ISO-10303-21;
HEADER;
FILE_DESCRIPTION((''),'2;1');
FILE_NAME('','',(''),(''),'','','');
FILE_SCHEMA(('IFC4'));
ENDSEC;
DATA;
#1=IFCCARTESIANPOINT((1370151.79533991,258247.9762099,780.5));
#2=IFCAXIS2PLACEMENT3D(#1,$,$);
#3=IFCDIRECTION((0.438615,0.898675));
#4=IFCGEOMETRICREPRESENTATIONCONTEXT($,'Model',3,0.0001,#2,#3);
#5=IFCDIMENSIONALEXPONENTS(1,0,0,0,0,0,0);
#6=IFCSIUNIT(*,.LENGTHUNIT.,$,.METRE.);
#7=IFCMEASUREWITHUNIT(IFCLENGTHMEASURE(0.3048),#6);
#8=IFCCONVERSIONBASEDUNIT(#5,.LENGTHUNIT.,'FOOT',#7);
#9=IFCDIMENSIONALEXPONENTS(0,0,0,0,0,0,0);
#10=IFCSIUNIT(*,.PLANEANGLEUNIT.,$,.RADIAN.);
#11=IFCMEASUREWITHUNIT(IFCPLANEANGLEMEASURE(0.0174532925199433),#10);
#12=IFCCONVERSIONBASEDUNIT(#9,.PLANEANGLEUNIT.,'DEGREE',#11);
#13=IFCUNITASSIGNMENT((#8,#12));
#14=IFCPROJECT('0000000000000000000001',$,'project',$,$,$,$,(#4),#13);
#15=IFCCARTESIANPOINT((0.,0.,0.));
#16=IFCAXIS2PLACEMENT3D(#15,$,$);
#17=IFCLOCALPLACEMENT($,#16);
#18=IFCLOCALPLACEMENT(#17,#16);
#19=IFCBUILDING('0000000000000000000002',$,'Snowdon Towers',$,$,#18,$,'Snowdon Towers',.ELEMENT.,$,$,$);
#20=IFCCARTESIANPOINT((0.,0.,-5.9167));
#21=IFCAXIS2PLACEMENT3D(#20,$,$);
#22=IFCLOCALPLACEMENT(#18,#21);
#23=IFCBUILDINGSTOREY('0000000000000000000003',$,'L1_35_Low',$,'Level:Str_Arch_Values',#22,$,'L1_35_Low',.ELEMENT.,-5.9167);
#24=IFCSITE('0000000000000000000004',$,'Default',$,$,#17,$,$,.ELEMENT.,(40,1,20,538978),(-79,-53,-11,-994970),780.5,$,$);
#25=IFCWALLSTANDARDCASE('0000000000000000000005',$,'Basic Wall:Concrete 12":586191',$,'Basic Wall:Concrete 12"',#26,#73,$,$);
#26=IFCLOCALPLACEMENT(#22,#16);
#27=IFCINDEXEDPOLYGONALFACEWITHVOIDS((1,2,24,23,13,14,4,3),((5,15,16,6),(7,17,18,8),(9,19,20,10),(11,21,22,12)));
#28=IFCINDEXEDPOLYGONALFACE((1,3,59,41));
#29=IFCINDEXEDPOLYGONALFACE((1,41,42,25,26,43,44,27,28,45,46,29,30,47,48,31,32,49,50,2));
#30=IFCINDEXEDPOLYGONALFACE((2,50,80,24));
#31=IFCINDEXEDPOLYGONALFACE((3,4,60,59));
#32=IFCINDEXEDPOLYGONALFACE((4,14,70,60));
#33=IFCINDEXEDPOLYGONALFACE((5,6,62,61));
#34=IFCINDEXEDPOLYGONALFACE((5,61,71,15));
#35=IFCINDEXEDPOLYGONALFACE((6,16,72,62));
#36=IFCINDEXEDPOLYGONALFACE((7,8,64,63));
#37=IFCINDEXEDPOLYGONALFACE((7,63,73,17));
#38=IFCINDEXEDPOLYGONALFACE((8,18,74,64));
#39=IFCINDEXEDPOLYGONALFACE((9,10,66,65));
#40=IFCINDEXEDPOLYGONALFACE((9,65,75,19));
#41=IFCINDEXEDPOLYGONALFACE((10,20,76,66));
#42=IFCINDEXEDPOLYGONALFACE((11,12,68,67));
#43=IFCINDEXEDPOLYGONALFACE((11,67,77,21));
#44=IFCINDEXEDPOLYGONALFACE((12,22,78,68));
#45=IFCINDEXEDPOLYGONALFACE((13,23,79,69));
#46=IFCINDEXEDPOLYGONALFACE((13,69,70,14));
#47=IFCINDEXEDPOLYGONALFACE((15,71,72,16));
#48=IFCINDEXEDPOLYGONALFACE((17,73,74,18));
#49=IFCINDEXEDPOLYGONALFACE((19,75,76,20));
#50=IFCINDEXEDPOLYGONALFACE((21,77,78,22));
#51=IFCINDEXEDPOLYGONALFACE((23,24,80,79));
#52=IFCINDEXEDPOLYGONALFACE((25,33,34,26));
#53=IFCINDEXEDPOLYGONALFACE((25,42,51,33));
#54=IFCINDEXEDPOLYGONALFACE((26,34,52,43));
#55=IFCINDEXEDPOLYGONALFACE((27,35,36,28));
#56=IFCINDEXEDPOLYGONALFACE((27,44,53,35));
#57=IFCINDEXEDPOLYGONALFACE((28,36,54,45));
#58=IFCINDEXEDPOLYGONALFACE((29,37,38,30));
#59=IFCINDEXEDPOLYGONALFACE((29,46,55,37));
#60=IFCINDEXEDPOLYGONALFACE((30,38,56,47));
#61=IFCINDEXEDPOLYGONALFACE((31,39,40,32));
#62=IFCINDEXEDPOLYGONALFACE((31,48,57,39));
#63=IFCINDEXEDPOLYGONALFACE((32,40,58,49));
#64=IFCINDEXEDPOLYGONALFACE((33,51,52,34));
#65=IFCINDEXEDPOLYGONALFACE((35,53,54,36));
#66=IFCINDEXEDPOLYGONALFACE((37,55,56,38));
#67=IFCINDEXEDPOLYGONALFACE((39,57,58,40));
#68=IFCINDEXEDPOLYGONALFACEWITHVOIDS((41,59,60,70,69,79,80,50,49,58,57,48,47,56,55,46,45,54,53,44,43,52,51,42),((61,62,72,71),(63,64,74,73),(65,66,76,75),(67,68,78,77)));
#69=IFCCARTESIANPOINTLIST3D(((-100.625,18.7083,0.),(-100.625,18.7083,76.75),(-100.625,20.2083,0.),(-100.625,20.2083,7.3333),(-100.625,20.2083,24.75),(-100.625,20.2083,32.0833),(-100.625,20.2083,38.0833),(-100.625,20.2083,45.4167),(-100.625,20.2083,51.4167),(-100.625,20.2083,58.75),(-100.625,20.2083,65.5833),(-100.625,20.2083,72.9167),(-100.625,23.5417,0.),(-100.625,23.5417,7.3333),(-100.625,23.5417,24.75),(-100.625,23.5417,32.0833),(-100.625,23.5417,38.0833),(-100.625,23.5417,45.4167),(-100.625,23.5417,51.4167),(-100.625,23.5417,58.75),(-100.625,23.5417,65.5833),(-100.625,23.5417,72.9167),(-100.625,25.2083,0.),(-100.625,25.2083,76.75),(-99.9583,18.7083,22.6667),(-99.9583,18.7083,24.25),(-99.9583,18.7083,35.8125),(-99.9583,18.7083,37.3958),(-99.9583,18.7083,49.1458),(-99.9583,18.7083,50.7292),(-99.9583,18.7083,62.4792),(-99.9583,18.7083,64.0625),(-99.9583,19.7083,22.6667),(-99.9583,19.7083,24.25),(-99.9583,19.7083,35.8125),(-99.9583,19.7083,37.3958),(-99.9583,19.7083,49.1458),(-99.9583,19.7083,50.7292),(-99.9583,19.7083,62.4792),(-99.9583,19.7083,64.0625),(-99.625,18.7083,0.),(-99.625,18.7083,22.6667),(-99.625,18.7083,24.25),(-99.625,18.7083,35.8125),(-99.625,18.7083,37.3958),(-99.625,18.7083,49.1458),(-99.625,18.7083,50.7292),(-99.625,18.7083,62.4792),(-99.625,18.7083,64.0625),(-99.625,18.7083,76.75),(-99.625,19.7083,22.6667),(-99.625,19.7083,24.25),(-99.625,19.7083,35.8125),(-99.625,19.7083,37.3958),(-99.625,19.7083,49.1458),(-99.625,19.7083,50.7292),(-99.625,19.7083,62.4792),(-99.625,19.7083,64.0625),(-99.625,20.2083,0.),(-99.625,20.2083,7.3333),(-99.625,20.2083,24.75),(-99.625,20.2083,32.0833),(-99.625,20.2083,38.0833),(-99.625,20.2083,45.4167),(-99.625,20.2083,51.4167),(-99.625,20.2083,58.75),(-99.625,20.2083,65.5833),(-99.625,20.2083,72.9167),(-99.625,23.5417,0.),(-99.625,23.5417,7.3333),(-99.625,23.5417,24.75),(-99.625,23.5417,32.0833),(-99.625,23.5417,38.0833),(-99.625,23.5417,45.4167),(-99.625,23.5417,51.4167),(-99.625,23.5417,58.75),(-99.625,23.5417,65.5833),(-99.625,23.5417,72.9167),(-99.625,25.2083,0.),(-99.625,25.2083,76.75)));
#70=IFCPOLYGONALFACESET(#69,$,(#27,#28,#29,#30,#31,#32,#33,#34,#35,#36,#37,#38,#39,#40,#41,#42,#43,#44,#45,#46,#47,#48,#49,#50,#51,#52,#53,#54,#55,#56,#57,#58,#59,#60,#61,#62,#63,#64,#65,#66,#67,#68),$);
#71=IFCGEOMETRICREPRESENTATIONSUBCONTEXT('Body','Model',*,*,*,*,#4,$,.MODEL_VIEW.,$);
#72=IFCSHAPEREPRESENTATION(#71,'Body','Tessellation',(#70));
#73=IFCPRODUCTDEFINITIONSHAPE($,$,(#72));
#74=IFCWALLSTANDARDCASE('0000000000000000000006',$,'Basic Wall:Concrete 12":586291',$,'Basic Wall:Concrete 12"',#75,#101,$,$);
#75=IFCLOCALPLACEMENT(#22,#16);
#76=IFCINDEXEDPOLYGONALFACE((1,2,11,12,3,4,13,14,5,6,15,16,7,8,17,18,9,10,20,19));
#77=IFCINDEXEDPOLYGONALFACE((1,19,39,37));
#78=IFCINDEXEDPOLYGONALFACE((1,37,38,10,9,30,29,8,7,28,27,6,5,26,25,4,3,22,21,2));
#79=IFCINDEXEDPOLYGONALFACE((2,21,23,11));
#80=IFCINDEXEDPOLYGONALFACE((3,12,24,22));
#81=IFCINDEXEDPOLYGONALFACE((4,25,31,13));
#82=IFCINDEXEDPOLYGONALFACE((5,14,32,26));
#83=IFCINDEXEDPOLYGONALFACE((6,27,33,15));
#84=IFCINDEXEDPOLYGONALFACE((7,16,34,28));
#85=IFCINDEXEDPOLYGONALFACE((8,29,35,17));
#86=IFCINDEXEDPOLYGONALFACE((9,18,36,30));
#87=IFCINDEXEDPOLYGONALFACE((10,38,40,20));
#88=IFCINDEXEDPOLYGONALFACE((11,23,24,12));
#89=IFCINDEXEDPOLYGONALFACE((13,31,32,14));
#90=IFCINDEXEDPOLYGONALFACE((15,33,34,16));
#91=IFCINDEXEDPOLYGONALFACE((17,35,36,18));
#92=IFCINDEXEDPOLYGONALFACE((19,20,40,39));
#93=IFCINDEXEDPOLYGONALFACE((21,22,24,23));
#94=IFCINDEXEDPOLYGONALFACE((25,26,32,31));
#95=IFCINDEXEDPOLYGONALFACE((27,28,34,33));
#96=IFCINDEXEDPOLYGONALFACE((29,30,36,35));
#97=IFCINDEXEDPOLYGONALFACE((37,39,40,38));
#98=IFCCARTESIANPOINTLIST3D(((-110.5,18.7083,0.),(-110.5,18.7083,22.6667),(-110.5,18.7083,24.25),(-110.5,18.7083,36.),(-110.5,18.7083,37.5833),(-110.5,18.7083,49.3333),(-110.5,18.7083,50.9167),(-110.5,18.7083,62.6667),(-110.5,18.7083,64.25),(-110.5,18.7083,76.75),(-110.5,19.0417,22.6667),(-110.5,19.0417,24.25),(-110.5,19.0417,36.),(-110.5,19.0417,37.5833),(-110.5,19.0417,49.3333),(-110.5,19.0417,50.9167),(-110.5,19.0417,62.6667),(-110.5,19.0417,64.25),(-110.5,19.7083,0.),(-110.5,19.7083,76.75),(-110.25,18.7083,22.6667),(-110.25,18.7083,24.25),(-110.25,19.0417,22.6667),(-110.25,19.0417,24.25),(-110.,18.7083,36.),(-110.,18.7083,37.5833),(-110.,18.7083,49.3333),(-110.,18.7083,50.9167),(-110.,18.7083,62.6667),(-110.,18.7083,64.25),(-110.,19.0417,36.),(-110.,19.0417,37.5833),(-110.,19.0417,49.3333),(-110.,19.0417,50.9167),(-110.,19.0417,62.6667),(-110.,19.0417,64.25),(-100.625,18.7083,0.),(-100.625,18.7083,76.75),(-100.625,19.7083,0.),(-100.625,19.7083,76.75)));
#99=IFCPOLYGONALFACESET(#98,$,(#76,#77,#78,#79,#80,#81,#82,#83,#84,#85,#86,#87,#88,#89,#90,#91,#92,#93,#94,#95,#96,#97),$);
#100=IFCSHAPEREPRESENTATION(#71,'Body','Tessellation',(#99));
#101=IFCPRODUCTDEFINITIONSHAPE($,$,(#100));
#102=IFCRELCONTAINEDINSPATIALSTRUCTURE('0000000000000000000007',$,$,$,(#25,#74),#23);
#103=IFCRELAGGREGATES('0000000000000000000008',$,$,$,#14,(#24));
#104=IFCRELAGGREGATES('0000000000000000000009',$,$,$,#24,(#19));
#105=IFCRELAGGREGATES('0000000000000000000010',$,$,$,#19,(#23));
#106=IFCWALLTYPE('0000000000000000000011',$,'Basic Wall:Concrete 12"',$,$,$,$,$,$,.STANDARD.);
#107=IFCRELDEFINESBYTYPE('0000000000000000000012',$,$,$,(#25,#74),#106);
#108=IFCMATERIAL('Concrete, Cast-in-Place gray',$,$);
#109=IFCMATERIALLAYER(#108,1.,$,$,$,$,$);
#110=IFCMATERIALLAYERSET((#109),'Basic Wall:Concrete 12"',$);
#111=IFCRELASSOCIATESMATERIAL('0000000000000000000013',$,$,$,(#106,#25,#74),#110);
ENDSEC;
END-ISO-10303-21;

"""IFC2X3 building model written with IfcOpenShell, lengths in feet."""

from ifc_helpers import new_model, entity, si_unit, converted_unit, direction, frame, frame_2d, origin, place, context, subcontext, project, spatial, rectangle, extrude, material, layer, layer_set, layer_usage, type_object, element, save


model = new_model("IFC2X3")

# Units and contexts
model_context = context("Model", 3, precision=0.0001, world=frame((1370151.79533991, 258247.9762099, 780.5)), true_north=direction((0.438615, 0.898675)))
body_context = subcontext(model_context, "Body", "Model", "MODEL_VIEW")
ifc_project = project(units=[converted_unit("LENGTHUNIT", "FOOT", entity("IfcLengthMeasure", 0.3048), si_unit("LENGTHUNIT", "METRE"), dimensions=[1, 0, 0, 0, 0, 0, 0]), converted_unit("PLANEANGLEUNIT", "DEGREE", entity("IfcPlaneAngleMeasure", 0.0174532925199433), si_unit("PLANEANGLEUNIT", "RADIAN"), dimensions=[0, 0, 0, 0, 0, 0, 0])], contexts=[model_context])

# Site, building, storey
site_placement = place(None, origin())
site = spatial("IfcSite", under=ifc_project, at=site_placement, Name="Default", CompositionType="ELEMENT", RefLatitude=(40, 1, 20, 538978), RefLongitude=(-79, -53, -11, -994970), RefElevation=780.5)
building_placement = place(site_placement, origin())
building = spatial("IfcBuilding", under=site, at=building_placement, Name="Snowdon Towers", LongName="Snowdon Towers", CompositionType="ELEMENT")
storey_placement = place(building_placement, frame((0.0, 0.0, -5.9167)))
storey = spatial("IfcBuildingStorey", under=building, at=storey_placement, Name="L1_35_Low", ObjectType="Level:Str_Arch_Values", LongName="L1_35_Low", CompositionType="ELEMENT", Elevation=-5.9167)

# Shared definitions
ifc_material = material(Name="Concrete, Cast-in-Place gray")

# Walls, openings
ifc_layer = layer(ifc_material, 1.0)
ifc_layer_set = layer_set([ifc_layer], Name="Basic Wall:Concrete 12\"")
ifc_layer_usage_1 = layer_usage(ifc_layer_set, "AXIS2", "POSITIVE", -0.5)
wall_type = type_object("IfcWallType", Name="Basic Wall:Concrete 12\"", PredefinedType="STANDARD", material=ifc_layer_set)
wall_1_placement = place(storey_placement, frame((-100.125, 25.2083, 0.0), z_axis=(0.0, 0.0, 1.0), x_axis=(0.0, -1.0, 0.0)))
wall_1 = element("IfcWallStandardCase", 1, at=wall_1_placement, inside=storey, type_object=wall_type, material=ifc_layer_usage_1, Name="Basic Wall:Concrete 12\":586191", ObjectType="Basic Wall:Concrete 12\"", context=body_context, shape_type="SweptSolid", body=[
    extrude(rectangle(XDim=6.5, YDim=1.0, at=frame_2d((3.25, 0.0), x_axis=(1.0, 0.0))), origin(), (0.0, 0.0, 1.0), 76.75),
])
opening_1_placement = place(wall_1_placement, origin())
element("IfcOpeningElement", 2, at=opening_1_placement, cuts=wall_1, ObjectType="Opening", context=body_context, shape_type="SweptSolid", body=[
    extrude(rectangle(XDim=7.3333, YDim=3.3333, at=frame_2d((0.0, 0.0), x_axis=(1.0, 0.0))), frame((3.3333, -4.5, 3.6667), z_axis=(0.0, 1.0, 0.0), x_axis=(0.0, 0.0, 1.0)), (0.0, 0.0, 1.0), 10.0),
])
opening_2_placement = place(wall_1_placement, origin())
element("IfcOpeningElement", 3, at=opening_2_placement, cuts=wall_1, ObjectType="Recess", context=body_context, shape_type="SweptSolid", body=[
    extrude(rectangle(XDim=1.5833, YDim=1.0, at=frame_2d((0.0, 0.0), x_axis=(0.0, 1.0))), frame((6.0, 0.1667, 23.4583), z_axis=(0.0, 1.0, 0.0), x_axis=(1.0, 0.0, 0.0)), (0.0, 0.0, 1.0), 0.3333),
])
opening_3_placement = place(wall_1_placement, origin())
element("IfcOpeningElement", 4, at=opening_3_placement, cuts=wall_1, ObjectType="Recess", context=body_context, shape_type="SweptSolid", body=[
    extrude(rectangle(XDim=1.5833, YDim=1.0, at=frame_2d((0.0, 0.0), x_axis=(0.0, 1.0))), frame((6.0, 0.1667, 63.2708), z_axis=(0.0, 1.0, 0.0), x_axis=(1.0, 0.0, 0.0)), (0.0, 0.0, 1.0), 0.3333),
])
opening_4_placement = place(wall_1_placement, origin())
element("IfcOpeningElement", 5, at=opening_4_placement, cuts=wall_1, ObjectType="Recess", context=body_context, shape_type="SweptSolid", body=[
    extrude(rectangle(XDim=1.5833, YDim=1.0, at=frame_2d((0.0, 0.0), x_axis=(0.0, 1.0))), frame((6.0, 0.1667, 36.6042), z_axis=(0.0, 1.0, 0.0), x_axis=(1.0, 0.0, 0.0)), (0.0, 0.0, 1.0), 0.3333),
])
opening_5_placement = place(wall_1_placement, origin())
element("IfcOpeningElement", 6, at=opening_5_placement, cuts=wall_1, ObjectType="Recess", context=body_context, shape_type="SweptSolid", body=[
    extrude(rectangle(XDim=1.5833, YDim=1.0, at=frame_2d((0.0, 0.0), x_axis=(0.0, 1.0))), frame((6.0, 0.1667, 49.9375), z_axis=(0.0, 1.0, 0.0), x_axis=(1.0, 0.0, 0.0)), (0.0, 0.0, 1.0), 0.3333),
])
opening_6_placement = place(wall_1_placement, origin())
element("IfcOpeningElement", 7, at=opening_6_placement, cuts=wall_1, ObjectType="Opening", context=body_context, shape_type="SweptSolid", body=[
    extrude(rectangle(XDim=7.3333, YDim=3.3333, at=frame_2d((0.0, 0.0), x_axis=(1.0, 0.0))), frame((3.3333, -4.5, 28.4167), z_axis=(0.0, 1.0, 0.0), x_axis=(0.0, 0.0, 1.0)), (0.0, 0.0, 1.0), 10.0),
])
opening_7_placement = place(wall_1_placement, origin())
element("IfcOpeningElement", 8, at=opening_7_placement, cuts=wall_1, ObjectType="Opening", context=body_context, shape_type="SweptSolid", body=[
    extrude(rectangle(XDim=7.3333, YDim=3.3333, at=frame_2d((0.0, 0.0), x_axis=(1.0, 0.0))), frame((3.3333, -4.5, 41.75), z_axis=(0.0, 1.0, 0.0), x_axis=(0.0, 0.0, 1.0)), (0.0, 0.0, 1.0), 10.0),
])
opening_8_placement = place(wall_1_placement, origin())
element("IfcOpeningElement", 9, at=opening_8_placement, cuts=wall_1, ObjectType="Opening", context=body_context, shape_type="SweptSolid", body=[
    extrude(rectangle(XDim=7.3333, YDim=3.3333, at=frame_2d((0.0, 0.0), x_axis=(1.0, 0.0))), frame((3.3333, -4.5, 55.0833), z_axis=(0.0, 1.0, 0.0), x_axis=(0.0, 0.0, 1.0)), (0.0, 0.0, 1.0), 10.0),
])
opening_9_placement = place(wall_1_placement, origin())
element("IfcOpeningElement", 10, at=opening_9_placement, cuts=wall_1, ObjectType="Opening", context=body_context, shape_type="SweptSolid", body=[
    extrude(rectangle(XDim=7.3333, YDim=3.3333, at=frame_2d((0.0, 0.0), x_axis=(1.0, 0.0))), frame((3.3333, -4.5, 69.25), z_axis=(0.0, 1.0, 0.0), x_axis=(0.0, 0.0, 1.0)), (0.0, 0.0, 1.0), 10.0),
])
ifc_layer_usage_2 = layer_usage(ifc_layer_set, "AXIS2", "POSITIVE", -0.5)
wall_2_placement = place(storey_placement, frame((-100.625, 19.2083, 0.0), z_axis=(0.0, 0.0, 1.0), x_axis=(-1.0, 0.0, 0.0)))
wall_2 = element("IfcWallStandardCase", 11, at=wall_2_placement, inside=storey, type_object=wall_type, material=ifc_layer_usage_2, Name="Basic Wall:Concrete 12\":586291", ObjectType="Basic Wall:Concrete 12\"", context=body_context, shape_type="SweptSolid", body=[
    extrude(rectangle(XDim=9.875, YDim=1.0, at=frame_2d((4.9375, 0.0), x_axis=(-1.0, 0.0))), origin(), (0.0, 0.0, 1.0), 76.75),
])
opening_10_placement = place(wall_2_placement, origin())
element("IfcOpeningElement", 12, at=opening_10_placement, cuts=wall_2, ObjectType="Recess", context=body_context, shape_type="SweptSolid", body=[
    extrude(rectangle(XDim=1.5833, YDim=1.0, at=frame_2d((0.0, 0.0), x_axis=(0.0, 1.0))), frame((10.125, 0.1667, 23.4583), z_axis=(0.0, 1.0, 0.0), x_axis=(1.0, 0.0, 0.0)), (0.0, 0.0, 1.0), 0.3333),
])
opening_11_placement = place(wall_2_placement, origin())
element("IfcOpeningElement", 13, at=opening_11_placement, cuts=wall_2, ObjectType="Recess", context=body_context, shape_type="SweptSolid", body=[
    extrude(rectangle(XDim=1.5833, YDim=1.0, at=frame_2d((0.0, 0.0), x_axis=(0.0, 1.0))), frame((9.875, 0.1667, 63.4583), z_axis=(0.0, 1.0, 0.0), x_axis=(1.0, 0.0, 0.0)), (0.0, 0.0, 1.0), 0.3333),
])
opening_12_placement = place(wall_2_placement, origin())
element("IfcOpeningElement", 14, at=opening_12_placement, cuts=wall_2, ObjectType="Recess", context=body_context, shape_type="SweptSolid", body=[
    extrude(rectangle(XDim=1.5833, YDim=1.0, at=frame_2d((0.0, 0.0), x_axis=(0.0, 1.0))), frame((9.875, 0.1667, 36.7917), z_axis=(0.0, 1.0, 0.0), x_axis=(1.0, 0.0, 0.0)), (0.0, 0.0, 1.0), 0.3333),
])
opening_13_placement = place(wall_2_placement, origin())
element("IfcOpeningElement", 15, at=opening_13_placement, cuts=wall_2, ObjectType="Recess", context=body_context, shape_type="SweptSolid", body=[
    extrude(rectangle(XDim=1.5833, YDim=1.0, at=frame_2d((0.0, 0.0), x_axis=(0.0, 1.0))), frame((9.875, 0.1667, 50.125), z_axis=(0.0, 1.0, 0.0), x_axis=(1.0, 0.0, 0.0)), (0.0, 0.0, 1.0), 0.3333),
])
opening_14_placement = place(wall_2_placement, origin())
element("IfcOpeningElement", 16, at=opening_14_placement, cuts=wall_2, ObjectType="Opening", context=body_context, shape_type="SweptSolid", body=[
    extrude(rectangle(XDim=1.5833, YDim=0.3333, at=frame_2d((0.0, 0.0), x_axis=(0.0, 1.0))), frame((-0.8333, -0.5, 23.4583), z_axis=(0.0, 1.0, 0.0), x_axis=(-1.0, 0.0, 0.0)), (0.0, 0.0, 1.0), 1.0),
])
opening_15_placement = place(wall_2_placement, origin())
element("IfcOpeningElement", 17, at=opening_15_placement, cuts=wall_2, ObjectType="Opening", context=body_context, shape_type="SweptSolid", body=[
    extrude(rectangle(XDim=1.5833, YDim=0.3333, at=frame_2d((0.0, 0.0), x_axis=(0.0, 1.0))), frame((-0.8333, -0.5, 63.2708), z_axis=(0.0, 1.0, 0.0), x_axis=(-1.0, 0.0, 0.0)), (0.0, 0.0, 1.0), 1.0),
])
opening_16_placement = place(wall_2_placement, origin())
element("IfcOpeningElement", 18, at=opening_16_placement, cuts=wall_2, ObjectType="Opening", context=body_context, shape_type="SweptSolid", body=[
    extrude(rectangle(XDim=1.5833, YDim=0.3333, at=frame_2d((0.0, 0.0), x_axis=(0.0, 1.0))), frame((-0.8333, -0.5, 36.6042), z_axis=(0.0, 1.0, 0.0), x_axis=(-1.0, 0.0, 0.0)), (0.0, 0.0, 1.0), 1.0),
])
opening_17_placement = place(wall_2_placement, origin())
element("IfcOpeningElement", 19, at=opening_17_placement, cuts=wall_2, ObjectType="Opening", context=body_context, shape_type="SweptSolid", body=[
    extrude(rectangle(XDim=1.5833, YDim=0.3333, at=frame_2d((0.0, 0.0), x_axis=(0.0, 1.0))), frame((-0.8333, -0.5, 49.9375), z_axis=(0.0, 1.0, 0.0), x_axis=(-1.0, 0.0, 0.0)), (0.0, 0.0, 1.0), 1.0),
])

save(model, "model.ifc")
